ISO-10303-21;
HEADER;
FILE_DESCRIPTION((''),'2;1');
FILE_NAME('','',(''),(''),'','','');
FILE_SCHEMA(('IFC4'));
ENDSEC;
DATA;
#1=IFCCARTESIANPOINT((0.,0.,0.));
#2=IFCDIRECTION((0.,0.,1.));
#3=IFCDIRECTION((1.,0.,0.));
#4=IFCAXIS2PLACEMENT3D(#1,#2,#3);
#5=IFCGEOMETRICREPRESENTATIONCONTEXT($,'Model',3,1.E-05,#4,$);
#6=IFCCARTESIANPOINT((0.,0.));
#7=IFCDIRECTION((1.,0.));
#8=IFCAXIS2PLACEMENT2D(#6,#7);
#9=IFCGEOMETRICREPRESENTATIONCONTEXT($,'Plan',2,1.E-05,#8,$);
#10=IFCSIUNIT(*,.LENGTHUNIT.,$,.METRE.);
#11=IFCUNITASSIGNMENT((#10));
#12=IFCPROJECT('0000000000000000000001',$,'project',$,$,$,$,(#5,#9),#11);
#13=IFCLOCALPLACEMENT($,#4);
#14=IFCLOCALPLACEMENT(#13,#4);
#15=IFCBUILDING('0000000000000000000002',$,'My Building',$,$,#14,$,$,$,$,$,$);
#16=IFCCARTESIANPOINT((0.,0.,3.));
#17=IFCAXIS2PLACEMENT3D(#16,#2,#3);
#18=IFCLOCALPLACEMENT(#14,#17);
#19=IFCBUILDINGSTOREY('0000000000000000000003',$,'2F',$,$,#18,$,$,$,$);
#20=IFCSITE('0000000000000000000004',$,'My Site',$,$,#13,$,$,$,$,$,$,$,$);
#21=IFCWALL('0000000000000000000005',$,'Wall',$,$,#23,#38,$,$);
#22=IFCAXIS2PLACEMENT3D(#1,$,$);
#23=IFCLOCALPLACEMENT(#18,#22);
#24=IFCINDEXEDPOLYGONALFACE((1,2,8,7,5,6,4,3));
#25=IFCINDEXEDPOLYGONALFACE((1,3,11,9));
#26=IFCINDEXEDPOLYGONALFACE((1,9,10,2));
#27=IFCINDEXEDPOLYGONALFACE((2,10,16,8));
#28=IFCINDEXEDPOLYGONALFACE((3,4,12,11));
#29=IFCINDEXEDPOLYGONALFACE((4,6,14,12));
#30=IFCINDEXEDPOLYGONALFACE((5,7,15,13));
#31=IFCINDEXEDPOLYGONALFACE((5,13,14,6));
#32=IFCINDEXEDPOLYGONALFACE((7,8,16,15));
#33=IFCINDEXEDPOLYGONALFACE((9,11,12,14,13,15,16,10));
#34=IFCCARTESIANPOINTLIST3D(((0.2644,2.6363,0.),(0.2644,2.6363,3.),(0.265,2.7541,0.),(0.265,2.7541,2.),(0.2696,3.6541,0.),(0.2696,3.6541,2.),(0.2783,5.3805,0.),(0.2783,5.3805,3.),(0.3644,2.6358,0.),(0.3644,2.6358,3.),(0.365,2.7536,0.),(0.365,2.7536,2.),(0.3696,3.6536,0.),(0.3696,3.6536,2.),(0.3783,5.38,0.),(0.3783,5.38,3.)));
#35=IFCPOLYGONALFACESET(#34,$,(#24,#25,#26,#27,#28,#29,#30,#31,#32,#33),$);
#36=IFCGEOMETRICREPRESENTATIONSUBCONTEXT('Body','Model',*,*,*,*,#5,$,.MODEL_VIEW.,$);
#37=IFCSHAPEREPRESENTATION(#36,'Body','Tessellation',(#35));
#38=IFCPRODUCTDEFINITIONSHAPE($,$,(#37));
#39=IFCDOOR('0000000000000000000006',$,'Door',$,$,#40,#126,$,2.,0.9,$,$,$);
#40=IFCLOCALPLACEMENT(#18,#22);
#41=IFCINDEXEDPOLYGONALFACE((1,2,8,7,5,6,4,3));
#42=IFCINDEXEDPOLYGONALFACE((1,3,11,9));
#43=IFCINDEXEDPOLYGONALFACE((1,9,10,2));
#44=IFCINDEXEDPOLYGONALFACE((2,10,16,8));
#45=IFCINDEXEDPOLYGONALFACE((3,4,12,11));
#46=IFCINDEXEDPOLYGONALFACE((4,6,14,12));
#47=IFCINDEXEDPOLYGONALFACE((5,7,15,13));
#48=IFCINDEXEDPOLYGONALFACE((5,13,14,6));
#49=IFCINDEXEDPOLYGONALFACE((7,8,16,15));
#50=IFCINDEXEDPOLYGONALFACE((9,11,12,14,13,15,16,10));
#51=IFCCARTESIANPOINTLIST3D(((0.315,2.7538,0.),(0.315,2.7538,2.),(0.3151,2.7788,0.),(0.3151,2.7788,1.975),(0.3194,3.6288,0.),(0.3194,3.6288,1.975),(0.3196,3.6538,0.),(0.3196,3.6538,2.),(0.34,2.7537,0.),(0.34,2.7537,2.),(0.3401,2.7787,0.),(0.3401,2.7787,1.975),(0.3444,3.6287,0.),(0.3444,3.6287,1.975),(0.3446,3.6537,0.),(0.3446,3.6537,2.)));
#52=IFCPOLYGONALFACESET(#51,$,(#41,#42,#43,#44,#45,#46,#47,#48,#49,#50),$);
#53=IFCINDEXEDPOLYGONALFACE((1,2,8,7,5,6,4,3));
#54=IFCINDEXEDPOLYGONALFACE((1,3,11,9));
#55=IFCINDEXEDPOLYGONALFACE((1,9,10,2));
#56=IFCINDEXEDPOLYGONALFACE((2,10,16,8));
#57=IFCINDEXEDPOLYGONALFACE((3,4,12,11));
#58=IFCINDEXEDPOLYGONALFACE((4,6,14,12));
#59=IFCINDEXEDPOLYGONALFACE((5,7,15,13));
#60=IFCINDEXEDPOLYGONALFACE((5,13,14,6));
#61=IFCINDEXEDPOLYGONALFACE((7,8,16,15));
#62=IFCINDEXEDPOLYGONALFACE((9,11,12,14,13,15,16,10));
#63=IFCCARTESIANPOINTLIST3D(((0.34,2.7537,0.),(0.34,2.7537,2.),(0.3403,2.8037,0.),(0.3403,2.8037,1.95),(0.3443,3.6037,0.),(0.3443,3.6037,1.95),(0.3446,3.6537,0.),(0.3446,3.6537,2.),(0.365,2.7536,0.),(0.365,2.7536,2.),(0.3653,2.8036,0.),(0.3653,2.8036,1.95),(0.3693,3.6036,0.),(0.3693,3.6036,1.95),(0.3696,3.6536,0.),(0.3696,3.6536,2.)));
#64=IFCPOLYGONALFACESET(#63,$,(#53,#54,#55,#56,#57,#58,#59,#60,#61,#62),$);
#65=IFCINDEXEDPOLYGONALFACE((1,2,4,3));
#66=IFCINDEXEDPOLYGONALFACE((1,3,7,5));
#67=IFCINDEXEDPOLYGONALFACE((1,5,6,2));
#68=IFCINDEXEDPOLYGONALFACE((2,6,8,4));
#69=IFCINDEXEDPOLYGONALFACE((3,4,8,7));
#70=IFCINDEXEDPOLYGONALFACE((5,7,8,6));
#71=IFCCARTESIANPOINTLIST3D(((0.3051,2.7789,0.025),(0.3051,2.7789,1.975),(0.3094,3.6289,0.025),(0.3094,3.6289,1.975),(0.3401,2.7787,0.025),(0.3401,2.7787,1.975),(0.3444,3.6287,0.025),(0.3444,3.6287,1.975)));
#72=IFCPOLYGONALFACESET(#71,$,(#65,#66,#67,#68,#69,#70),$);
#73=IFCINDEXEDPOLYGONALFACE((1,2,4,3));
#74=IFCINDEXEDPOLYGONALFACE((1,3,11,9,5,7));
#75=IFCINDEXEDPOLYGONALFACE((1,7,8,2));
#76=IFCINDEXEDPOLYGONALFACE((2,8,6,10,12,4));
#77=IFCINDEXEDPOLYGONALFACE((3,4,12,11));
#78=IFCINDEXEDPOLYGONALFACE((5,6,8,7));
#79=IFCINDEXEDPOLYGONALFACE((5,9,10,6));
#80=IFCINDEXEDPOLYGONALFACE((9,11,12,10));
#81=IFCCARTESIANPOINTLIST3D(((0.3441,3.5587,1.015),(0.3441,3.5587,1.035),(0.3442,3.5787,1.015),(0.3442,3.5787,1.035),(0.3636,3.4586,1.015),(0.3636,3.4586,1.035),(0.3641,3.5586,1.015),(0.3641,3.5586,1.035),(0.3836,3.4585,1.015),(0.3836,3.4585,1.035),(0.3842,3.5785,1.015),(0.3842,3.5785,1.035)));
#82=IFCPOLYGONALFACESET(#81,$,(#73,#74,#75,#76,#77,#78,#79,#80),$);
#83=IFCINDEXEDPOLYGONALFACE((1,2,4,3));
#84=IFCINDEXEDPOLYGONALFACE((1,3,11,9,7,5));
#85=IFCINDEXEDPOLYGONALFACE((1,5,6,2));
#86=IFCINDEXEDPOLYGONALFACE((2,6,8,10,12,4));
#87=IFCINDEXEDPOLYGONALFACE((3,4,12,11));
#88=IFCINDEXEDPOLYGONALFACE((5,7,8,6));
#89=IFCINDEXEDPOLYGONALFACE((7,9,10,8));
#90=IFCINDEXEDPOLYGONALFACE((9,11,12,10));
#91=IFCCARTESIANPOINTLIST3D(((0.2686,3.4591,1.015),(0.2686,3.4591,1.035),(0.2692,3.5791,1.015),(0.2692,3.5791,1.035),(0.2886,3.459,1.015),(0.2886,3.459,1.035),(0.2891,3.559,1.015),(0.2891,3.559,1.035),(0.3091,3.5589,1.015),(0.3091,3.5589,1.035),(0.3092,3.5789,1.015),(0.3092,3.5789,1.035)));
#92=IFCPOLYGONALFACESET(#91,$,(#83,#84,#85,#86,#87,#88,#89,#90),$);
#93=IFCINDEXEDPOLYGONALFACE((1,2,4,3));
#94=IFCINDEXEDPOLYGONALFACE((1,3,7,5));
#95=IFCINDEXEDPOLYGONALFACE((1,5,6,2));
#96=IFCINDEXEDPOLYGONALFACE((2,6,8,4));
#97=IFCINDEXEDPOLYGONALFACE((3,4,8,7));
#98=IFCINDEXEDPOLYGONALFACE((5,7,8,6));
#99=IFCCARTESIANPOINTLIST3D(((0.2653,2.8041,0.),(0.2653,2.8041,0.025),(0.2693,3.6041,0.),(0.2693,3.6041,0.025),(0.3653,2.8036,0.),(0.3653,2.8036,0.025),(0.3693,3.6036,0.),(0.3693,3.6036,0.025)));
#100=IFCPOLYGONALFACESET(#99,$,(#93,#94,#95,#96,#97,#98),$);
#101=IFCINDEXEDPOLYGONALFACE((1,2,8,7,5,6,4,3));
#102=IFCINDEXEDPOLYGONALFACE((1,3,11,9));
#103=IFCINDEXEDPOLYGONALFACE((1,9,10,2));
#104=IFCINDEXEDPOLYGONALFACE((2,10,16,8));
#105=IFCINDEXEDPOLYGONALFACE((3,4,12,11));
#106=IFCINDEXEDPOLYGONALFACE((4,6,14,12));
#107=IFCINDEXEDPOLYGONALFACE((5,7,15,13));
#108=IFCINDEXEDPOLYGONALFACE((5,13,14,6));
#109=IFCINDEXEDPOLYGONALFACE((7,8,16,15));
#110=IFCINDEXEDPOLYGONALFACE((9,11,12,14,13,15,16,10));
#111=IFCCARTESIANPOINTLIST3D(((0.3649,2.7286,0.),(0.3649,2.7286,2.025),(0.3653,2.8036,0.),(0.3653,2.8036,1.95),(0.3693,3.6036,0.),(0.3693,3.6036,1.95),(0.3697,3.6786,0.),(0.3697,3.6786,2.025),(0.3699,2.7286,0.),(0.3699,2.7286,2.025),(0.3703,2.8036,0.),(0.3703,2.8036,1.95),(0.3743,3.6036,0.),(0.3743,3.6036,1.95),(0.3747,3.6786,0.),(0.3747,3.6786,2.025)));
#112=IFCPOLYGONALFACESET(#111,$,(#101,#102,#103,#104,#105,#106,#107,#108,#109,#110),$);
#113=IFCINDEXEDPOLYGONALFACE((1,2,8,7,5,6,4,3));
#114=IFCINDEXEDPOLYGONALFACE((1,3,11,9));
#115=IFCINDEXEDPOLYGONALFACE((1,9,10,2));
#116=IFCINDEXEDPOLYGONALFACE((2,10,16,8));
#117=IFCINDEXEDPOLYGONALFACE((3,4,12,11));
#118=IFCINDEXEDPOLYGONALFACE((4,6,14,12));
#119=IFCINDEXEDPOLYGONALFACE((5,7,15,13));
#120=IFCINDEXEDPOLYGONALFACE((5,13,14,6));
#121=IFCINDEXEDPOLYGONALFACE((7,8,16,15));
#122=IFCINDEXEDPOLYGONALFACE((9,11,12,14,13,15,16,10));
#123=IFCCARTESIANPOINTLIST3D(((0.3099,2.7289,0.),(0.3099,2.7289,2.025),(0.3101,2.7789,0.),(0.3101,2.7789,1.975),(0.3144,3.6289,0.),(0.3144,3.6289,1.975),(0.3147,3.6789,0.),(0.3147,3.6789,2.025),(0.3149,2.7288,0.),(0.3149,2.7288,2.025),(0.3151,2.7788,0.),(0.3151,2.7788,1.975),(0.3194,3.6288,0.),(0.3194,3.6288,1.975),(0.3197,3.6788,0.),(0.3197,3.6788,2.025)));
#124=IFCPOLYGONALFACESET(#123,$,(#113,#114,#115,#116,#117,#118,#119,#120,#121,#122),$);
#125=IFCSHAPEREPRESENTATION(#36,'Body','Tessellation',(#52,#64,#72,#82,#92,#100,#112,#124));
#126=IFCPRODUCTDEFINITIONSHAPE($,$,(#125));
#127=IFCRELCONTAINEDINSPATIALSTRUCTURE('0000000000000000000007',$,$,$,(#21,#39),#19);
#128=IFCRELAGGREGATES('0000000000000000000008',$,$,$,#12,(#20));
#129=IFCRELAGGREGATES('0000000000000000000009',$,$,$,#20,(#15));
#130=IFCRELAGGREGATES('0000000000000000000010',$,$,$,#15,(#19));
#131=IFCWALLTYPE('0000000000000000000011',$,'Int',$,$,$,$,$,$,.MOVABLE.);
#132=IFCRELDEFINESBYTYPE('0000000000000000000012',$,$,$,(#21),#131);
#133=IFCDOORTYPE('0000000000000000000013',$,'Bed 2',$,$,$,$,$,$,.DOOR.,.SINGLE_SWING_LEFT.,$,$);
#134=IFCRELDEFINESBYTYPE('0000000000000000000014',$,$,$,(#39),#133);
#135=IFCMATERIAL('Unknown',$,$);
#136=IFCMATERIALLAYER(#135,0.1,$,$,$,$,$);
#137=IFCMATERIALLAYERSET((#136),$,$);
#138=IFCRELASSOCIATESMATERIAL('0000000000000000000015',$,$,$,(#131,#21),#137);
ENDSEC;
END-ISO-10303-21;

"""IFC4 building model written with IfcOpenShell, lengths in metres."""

from ifc_helpers import new_model, entity, si_unit, frame, origin_with_axes, origin_2d_with_axis, place, context, subcontext, project, spatial, line, indexed_curve, outline, extrude, shape, source, transform, mapped, material, layer, layer_set, layer_usage, type_object, type_shapes, element, fill, save


model = new_model("IFC4")

# Units and contexts
model_context = context("Model", 3, precision=1e-05, world=origin_with_axes())
plan_context = context("Plan", 2, precision=1e-05, world=origin_2d_with_axis())
body_context_1 = subcontext(model_context, "Body", "Model", "MODEL_VIEW")
body_context_2 = subcontext(plan_context, "Body", "Plan", "PLAN_VIEW")
ifc_project = project(units=[si_unit("LENGTHUNIT", "METRE")], contexts=[model_context, plan_context])

# Site, building, storey
site_placement = place(None, origin_with_axes())
site = spatial("IfcSite", under=ifc_project, at=site_placement, Name="My Site")
building_placement = place(site_placement, origin_with_axes())
building = spatial("IfcBuilding", under=site, at=building_placement, Name="My Building")
storey_placement = place(building_placement, frame((0.0, 0.0, 3.0), z_axis=(0.0, 0.0, 1.0), x_axis=(1.0, 0.0, 0.0)))
storey = spatial("IfcBuildingStorey", under=building, at=storey_placement, Name="2F")

# Shared definitions
ifc_material = material(Name="Unknown")

# Shared definitions
ifc_layer_1 = layer(ifc_material, 0.1)
ifc_layer_set_1 = layer_set([ifc_layer_1])
wall_type_1 = type_object("IfcWallType", Name="Int", PredefinedType="MOVABLE", material=ifc_layer_set_1)

# Wall, opening, door
ifc_layer_usage_1 = layer_usage(ifc_layer_set_1, "AXIS2", "POSITIVE", 0.0)
wall_1_placement = place(storey_placement, frame((0.3644, 2.6358, 0.0), z_axis=(0.0, 0.0, 1.0), x_axis=(0.005081, 0.999987, 0.0)))
wall_1 = element("IfcWall", 1, at=wall_1_placement, inside=storey, type_object=wall_type_1, material=ifc_layer_usage_1, Name="Wall", context=body_context_1, shape_type="SweptSolid", body=[
    extrude(outline(indexed_curve([(0.0, 0.0), (0.0, 0.1), (2.7442, 0.1), (2.7442, 0.0)], segments=[line(1, 2, 3, 4, 1)])), origin_with_axes(), (0.0, 0.0, 1.0), 3.0),
])
shared_shape_1 = source(origin_with_axes(), body_context_1, "Body", "SweptSolid", [
    extrude(outline(indexed_curve([(0.0, 0.0), (0.9, 0.0), (0.9, 2.0), (0.0, 2.0)], segments=[line(1, 2, 3, 4, 1)])), frame((0.0, -0.6, 0.0), z_axis=(0.0, -1.0, 0.0), x_axis=(1.0, 0.0, 0.0)), (0.0, 0.0, -1.0), 1.2),
])
opening_1_placement = place(wall_1_placement, frame((0.1178, 0.0, 0.0), z_axis=(0.0, 0.0, 1.0), x_axis=(1.0, 0.000001, 0.0)))
opening_1 = element("IfcOpeningElement", 2, at=opening_1_placement, cuts=wall_1, PredefinedType="OPENING", context=body_context_1, shape_type="MappedRepresentation", body=[
    mapped(shared_shape_1, transform((0.0, 0.0, 0.0), x_axis=(1.0, 0.0, 0.0), y_axis=(0.0, 1.0, 0.0), z_axis=(0.0, 0.0, 1.0), scale=1.0)),
])
door_type_1 = type_object("IfcDoorType", Name="Bed 2", OperationType="SINGLE_SWING_LEFT", PredefinedType="DOOR")
shared_shape_2 = source(origin_with_axes(), body_context_1, "Body", "SweptSolid", [
    extrude(outline(indexed_curve([(0.0, 0.0), (0.0, 2.0), (0.9, 2.0), (0.9, 0.0), (0.875, 0.0), (0.875, 1.975), (0.025, 1.975), (0.025, 0.0)], segments=[line(1, 2, 3, 4, 5, 6, 7, 8, 1)])), frame((0.0, 0.025, 0.0), z_axis=(0.0, -1.0, 0.0), x_axis=(1.0, 0.0, 0.0)), (0.0, 0.0, -1.0), 0.025),
    extrude(outline(indexed_curve([(0.0, 0.0), (0.0, 2.0), (0.9, 2.0), (0.9, 0.0), (0.85, 0.0), (0.85, 1.95), (0.05, 1.95), (0.05, 0.0)], segments=[line(1, 2, 3, 4, 5, 6, 7, 8, 1)])), frame((0.0, 0.0, 0.0), z_axis=(0.0, -1.0, 0.0), x_axis=(1.0, 0.0, 0.0)), (0.0, 0.0, -1.0), 0.025),
    extrude(outline(indexed_curve([(0.0, 0.0), (0.85, 0.0), (0.85, 0.035), (0.0, 0.035)], segments=[line(1, 2, 3, 4, 1)])), frame((0.025, 0.025, 0.025), z_axis=(0.0, 0.0, 1.0), x_axis=(1.0, 0.0, 0.0)), (0.0, 0.0, 1.0), 1.95),
    extrude(outline(indexed_curve([(0.0, 0.0), (0.0, -0.04), (-0.12, -0.04), (-0.12, -0.02), (-0.02, -0.02), (-0.02, 0.0)], segments=[line(1, 2, 3, 4, 5, 6, 1)])), frame((0.825, 0.025, 1.015), z_axis=(0.0, 0.0, 1.0), x_axis=(1.0, 0.0, 0.0)), (0.0, 0.0, 1.0), 0.02),
    extrude(outline(indexed_curve([(0.0, 0.0), (0.0, 0.04), (-0.12, 0.04), (-0.12, 0.02), (-0.02, 0.02), (-0.02, 0.0)], segments=[line(1, 2, 3, 4, 5, 6, 1)])), frame((0.825, 0.06, 1.015), z_axis=(0.0, 0.0, 1.0), x_axis=(1.0, 0.0, 0.0)), (0.0, 0.0, 1.0), 0.02),
    extrude(outline(indexed_curve([(0.0, 0.0), (0.8, 0.0), (0.8, 0.1), (0.0, 0.1)], segments=[line(1, 2, 3, 4, 1)])), frame((0.05, 0.0, 0.0), z_axis=(0.0, 0.0, 1.0), x_axis=(1.0, 0.0, 0.0)), (0.0, 0.0, 1.0), 0.025),
    extrude(outline(indexed_curve([(0.0, 0.0), (0.0, 2.025), (0.95, 2.025), (0.95, 0.0), (0.875, 0.0), (0.875, 1.95), (0.075, 1.95), (0.075, 0.0)], segments=[line(1, 2, 3, 4, 5, 6, 7, 8, 1)])), frame((-0.025, -0.005, 0.0), z_axis=(0.0, -1.0, 0.0), x_axis=(1.0, 0.0, 0.0)), (0.0, 0.0, -1.0), 0.005),
    extrude(outline(indexed_curve([(0.0, 0.0), (0.0, 2.025), (0.95, 2.025), (0.95, 0.0), (0.9, 0.0), (0.9, 1.975), (0.05, 1.975), (0.05, 0.0)], segments=[line(1, 2, 3, 4, 5, 6, 7, 8, 1)])), frame((-0.025, 0.05, 0.0), z_axis=(0.0, -1.0, 0.0), x_axis=(1.0, 0.0, 0.0)), (0.0, 0.0, -1.0), 0.005),
])
shared_shape_3 = source(origin_with_axes(), body_context_2, "Body", "Curve2D", [
    entity("IfcIndexedPolyCurve", entity("IfcCartesianPointList2D", [[0.0, 0.0], [0.0, 0.05], [0.025, 0.05], [0.025, 0.025], [0.05, 0.025], [0.05, 0.0]]), [entity("IfcLineIndex", [1, 2, 3, 4, 5, 6, 1])]),
    entity("IfcIndexedPolyCurve", entity("IfcCartesianPointList2D", [[0.9, 0.0], [0.9, 0.05], [0.875, 0.05], [0.875, 0.025], [0.85, 0.025], [0.85, 0.0]]), [entity("IfcLineIndex", [1, 2, 3, 4, 5, 6, 1])]),
    entity("IfcTrimmedCurve", entity("IfcEllipse", entity("IfcAxis2Placement2D", entity("IfcCartesianPoint", [0.06, 0.05]), entity("IfcDirection", [1.0, 0.0])), 0.815, 0.85), [entity("IfcCartesianPoint", [0.875, 0.05])], [entity("IfcCartesianPoint", [0.06, 0.9])], True, "CARTESIAN"),
    entity("IfcIndexedPolyCurve", entity("IfcCartesianPointList2D", [[0.025, 0.05], [0.06, 0.05], [0.06, 0.9], [0.025, 0.9]]), [entity("IfcLineIndex", [1, 2, 3, 4, 1])]),
])
type_shapes(door_type_1, [shared_shape_2, shared_shape_3])
door_1_placement = place(opening_1_placement, frame((0.0, 0.0, 0.0), z_axis=(0.0, 0.0, 1.0), x_axis=(1.0, 0.0, 0.0)))
door_1 = element("IfcDoor", 3, at=door_1_placement, inside=storey, type_object=door_type_1, Name="Door", OverallHeight=2.0, OverallWidth=0.9, shapes=[
    shape(body_context_1, "Body", "MappedRepresentation", [mapped(shared_shape_2, transform((0.0, 0.0, 0.0), x_axis=(1.0, 0.0, 0.0), y_axis=(0.0, 1.0, 0.0), z_axis=(0.0, 0.0, 1.0), scale=1.0))]),
    shape(body_context_2, "Body", "MappedRepresentation", [mapped(shared_shape_3, transform((0.0, 0.0, 0.0), x_axis=(1.0, 0.0, 0.0), y_axis=(0.0, 1.0, 0.0), z_axis=(0.0, 0.0, 1.0), scale=1.0))]),
])
fill(opening_1, door_1)

save(model, "model.ifc")
